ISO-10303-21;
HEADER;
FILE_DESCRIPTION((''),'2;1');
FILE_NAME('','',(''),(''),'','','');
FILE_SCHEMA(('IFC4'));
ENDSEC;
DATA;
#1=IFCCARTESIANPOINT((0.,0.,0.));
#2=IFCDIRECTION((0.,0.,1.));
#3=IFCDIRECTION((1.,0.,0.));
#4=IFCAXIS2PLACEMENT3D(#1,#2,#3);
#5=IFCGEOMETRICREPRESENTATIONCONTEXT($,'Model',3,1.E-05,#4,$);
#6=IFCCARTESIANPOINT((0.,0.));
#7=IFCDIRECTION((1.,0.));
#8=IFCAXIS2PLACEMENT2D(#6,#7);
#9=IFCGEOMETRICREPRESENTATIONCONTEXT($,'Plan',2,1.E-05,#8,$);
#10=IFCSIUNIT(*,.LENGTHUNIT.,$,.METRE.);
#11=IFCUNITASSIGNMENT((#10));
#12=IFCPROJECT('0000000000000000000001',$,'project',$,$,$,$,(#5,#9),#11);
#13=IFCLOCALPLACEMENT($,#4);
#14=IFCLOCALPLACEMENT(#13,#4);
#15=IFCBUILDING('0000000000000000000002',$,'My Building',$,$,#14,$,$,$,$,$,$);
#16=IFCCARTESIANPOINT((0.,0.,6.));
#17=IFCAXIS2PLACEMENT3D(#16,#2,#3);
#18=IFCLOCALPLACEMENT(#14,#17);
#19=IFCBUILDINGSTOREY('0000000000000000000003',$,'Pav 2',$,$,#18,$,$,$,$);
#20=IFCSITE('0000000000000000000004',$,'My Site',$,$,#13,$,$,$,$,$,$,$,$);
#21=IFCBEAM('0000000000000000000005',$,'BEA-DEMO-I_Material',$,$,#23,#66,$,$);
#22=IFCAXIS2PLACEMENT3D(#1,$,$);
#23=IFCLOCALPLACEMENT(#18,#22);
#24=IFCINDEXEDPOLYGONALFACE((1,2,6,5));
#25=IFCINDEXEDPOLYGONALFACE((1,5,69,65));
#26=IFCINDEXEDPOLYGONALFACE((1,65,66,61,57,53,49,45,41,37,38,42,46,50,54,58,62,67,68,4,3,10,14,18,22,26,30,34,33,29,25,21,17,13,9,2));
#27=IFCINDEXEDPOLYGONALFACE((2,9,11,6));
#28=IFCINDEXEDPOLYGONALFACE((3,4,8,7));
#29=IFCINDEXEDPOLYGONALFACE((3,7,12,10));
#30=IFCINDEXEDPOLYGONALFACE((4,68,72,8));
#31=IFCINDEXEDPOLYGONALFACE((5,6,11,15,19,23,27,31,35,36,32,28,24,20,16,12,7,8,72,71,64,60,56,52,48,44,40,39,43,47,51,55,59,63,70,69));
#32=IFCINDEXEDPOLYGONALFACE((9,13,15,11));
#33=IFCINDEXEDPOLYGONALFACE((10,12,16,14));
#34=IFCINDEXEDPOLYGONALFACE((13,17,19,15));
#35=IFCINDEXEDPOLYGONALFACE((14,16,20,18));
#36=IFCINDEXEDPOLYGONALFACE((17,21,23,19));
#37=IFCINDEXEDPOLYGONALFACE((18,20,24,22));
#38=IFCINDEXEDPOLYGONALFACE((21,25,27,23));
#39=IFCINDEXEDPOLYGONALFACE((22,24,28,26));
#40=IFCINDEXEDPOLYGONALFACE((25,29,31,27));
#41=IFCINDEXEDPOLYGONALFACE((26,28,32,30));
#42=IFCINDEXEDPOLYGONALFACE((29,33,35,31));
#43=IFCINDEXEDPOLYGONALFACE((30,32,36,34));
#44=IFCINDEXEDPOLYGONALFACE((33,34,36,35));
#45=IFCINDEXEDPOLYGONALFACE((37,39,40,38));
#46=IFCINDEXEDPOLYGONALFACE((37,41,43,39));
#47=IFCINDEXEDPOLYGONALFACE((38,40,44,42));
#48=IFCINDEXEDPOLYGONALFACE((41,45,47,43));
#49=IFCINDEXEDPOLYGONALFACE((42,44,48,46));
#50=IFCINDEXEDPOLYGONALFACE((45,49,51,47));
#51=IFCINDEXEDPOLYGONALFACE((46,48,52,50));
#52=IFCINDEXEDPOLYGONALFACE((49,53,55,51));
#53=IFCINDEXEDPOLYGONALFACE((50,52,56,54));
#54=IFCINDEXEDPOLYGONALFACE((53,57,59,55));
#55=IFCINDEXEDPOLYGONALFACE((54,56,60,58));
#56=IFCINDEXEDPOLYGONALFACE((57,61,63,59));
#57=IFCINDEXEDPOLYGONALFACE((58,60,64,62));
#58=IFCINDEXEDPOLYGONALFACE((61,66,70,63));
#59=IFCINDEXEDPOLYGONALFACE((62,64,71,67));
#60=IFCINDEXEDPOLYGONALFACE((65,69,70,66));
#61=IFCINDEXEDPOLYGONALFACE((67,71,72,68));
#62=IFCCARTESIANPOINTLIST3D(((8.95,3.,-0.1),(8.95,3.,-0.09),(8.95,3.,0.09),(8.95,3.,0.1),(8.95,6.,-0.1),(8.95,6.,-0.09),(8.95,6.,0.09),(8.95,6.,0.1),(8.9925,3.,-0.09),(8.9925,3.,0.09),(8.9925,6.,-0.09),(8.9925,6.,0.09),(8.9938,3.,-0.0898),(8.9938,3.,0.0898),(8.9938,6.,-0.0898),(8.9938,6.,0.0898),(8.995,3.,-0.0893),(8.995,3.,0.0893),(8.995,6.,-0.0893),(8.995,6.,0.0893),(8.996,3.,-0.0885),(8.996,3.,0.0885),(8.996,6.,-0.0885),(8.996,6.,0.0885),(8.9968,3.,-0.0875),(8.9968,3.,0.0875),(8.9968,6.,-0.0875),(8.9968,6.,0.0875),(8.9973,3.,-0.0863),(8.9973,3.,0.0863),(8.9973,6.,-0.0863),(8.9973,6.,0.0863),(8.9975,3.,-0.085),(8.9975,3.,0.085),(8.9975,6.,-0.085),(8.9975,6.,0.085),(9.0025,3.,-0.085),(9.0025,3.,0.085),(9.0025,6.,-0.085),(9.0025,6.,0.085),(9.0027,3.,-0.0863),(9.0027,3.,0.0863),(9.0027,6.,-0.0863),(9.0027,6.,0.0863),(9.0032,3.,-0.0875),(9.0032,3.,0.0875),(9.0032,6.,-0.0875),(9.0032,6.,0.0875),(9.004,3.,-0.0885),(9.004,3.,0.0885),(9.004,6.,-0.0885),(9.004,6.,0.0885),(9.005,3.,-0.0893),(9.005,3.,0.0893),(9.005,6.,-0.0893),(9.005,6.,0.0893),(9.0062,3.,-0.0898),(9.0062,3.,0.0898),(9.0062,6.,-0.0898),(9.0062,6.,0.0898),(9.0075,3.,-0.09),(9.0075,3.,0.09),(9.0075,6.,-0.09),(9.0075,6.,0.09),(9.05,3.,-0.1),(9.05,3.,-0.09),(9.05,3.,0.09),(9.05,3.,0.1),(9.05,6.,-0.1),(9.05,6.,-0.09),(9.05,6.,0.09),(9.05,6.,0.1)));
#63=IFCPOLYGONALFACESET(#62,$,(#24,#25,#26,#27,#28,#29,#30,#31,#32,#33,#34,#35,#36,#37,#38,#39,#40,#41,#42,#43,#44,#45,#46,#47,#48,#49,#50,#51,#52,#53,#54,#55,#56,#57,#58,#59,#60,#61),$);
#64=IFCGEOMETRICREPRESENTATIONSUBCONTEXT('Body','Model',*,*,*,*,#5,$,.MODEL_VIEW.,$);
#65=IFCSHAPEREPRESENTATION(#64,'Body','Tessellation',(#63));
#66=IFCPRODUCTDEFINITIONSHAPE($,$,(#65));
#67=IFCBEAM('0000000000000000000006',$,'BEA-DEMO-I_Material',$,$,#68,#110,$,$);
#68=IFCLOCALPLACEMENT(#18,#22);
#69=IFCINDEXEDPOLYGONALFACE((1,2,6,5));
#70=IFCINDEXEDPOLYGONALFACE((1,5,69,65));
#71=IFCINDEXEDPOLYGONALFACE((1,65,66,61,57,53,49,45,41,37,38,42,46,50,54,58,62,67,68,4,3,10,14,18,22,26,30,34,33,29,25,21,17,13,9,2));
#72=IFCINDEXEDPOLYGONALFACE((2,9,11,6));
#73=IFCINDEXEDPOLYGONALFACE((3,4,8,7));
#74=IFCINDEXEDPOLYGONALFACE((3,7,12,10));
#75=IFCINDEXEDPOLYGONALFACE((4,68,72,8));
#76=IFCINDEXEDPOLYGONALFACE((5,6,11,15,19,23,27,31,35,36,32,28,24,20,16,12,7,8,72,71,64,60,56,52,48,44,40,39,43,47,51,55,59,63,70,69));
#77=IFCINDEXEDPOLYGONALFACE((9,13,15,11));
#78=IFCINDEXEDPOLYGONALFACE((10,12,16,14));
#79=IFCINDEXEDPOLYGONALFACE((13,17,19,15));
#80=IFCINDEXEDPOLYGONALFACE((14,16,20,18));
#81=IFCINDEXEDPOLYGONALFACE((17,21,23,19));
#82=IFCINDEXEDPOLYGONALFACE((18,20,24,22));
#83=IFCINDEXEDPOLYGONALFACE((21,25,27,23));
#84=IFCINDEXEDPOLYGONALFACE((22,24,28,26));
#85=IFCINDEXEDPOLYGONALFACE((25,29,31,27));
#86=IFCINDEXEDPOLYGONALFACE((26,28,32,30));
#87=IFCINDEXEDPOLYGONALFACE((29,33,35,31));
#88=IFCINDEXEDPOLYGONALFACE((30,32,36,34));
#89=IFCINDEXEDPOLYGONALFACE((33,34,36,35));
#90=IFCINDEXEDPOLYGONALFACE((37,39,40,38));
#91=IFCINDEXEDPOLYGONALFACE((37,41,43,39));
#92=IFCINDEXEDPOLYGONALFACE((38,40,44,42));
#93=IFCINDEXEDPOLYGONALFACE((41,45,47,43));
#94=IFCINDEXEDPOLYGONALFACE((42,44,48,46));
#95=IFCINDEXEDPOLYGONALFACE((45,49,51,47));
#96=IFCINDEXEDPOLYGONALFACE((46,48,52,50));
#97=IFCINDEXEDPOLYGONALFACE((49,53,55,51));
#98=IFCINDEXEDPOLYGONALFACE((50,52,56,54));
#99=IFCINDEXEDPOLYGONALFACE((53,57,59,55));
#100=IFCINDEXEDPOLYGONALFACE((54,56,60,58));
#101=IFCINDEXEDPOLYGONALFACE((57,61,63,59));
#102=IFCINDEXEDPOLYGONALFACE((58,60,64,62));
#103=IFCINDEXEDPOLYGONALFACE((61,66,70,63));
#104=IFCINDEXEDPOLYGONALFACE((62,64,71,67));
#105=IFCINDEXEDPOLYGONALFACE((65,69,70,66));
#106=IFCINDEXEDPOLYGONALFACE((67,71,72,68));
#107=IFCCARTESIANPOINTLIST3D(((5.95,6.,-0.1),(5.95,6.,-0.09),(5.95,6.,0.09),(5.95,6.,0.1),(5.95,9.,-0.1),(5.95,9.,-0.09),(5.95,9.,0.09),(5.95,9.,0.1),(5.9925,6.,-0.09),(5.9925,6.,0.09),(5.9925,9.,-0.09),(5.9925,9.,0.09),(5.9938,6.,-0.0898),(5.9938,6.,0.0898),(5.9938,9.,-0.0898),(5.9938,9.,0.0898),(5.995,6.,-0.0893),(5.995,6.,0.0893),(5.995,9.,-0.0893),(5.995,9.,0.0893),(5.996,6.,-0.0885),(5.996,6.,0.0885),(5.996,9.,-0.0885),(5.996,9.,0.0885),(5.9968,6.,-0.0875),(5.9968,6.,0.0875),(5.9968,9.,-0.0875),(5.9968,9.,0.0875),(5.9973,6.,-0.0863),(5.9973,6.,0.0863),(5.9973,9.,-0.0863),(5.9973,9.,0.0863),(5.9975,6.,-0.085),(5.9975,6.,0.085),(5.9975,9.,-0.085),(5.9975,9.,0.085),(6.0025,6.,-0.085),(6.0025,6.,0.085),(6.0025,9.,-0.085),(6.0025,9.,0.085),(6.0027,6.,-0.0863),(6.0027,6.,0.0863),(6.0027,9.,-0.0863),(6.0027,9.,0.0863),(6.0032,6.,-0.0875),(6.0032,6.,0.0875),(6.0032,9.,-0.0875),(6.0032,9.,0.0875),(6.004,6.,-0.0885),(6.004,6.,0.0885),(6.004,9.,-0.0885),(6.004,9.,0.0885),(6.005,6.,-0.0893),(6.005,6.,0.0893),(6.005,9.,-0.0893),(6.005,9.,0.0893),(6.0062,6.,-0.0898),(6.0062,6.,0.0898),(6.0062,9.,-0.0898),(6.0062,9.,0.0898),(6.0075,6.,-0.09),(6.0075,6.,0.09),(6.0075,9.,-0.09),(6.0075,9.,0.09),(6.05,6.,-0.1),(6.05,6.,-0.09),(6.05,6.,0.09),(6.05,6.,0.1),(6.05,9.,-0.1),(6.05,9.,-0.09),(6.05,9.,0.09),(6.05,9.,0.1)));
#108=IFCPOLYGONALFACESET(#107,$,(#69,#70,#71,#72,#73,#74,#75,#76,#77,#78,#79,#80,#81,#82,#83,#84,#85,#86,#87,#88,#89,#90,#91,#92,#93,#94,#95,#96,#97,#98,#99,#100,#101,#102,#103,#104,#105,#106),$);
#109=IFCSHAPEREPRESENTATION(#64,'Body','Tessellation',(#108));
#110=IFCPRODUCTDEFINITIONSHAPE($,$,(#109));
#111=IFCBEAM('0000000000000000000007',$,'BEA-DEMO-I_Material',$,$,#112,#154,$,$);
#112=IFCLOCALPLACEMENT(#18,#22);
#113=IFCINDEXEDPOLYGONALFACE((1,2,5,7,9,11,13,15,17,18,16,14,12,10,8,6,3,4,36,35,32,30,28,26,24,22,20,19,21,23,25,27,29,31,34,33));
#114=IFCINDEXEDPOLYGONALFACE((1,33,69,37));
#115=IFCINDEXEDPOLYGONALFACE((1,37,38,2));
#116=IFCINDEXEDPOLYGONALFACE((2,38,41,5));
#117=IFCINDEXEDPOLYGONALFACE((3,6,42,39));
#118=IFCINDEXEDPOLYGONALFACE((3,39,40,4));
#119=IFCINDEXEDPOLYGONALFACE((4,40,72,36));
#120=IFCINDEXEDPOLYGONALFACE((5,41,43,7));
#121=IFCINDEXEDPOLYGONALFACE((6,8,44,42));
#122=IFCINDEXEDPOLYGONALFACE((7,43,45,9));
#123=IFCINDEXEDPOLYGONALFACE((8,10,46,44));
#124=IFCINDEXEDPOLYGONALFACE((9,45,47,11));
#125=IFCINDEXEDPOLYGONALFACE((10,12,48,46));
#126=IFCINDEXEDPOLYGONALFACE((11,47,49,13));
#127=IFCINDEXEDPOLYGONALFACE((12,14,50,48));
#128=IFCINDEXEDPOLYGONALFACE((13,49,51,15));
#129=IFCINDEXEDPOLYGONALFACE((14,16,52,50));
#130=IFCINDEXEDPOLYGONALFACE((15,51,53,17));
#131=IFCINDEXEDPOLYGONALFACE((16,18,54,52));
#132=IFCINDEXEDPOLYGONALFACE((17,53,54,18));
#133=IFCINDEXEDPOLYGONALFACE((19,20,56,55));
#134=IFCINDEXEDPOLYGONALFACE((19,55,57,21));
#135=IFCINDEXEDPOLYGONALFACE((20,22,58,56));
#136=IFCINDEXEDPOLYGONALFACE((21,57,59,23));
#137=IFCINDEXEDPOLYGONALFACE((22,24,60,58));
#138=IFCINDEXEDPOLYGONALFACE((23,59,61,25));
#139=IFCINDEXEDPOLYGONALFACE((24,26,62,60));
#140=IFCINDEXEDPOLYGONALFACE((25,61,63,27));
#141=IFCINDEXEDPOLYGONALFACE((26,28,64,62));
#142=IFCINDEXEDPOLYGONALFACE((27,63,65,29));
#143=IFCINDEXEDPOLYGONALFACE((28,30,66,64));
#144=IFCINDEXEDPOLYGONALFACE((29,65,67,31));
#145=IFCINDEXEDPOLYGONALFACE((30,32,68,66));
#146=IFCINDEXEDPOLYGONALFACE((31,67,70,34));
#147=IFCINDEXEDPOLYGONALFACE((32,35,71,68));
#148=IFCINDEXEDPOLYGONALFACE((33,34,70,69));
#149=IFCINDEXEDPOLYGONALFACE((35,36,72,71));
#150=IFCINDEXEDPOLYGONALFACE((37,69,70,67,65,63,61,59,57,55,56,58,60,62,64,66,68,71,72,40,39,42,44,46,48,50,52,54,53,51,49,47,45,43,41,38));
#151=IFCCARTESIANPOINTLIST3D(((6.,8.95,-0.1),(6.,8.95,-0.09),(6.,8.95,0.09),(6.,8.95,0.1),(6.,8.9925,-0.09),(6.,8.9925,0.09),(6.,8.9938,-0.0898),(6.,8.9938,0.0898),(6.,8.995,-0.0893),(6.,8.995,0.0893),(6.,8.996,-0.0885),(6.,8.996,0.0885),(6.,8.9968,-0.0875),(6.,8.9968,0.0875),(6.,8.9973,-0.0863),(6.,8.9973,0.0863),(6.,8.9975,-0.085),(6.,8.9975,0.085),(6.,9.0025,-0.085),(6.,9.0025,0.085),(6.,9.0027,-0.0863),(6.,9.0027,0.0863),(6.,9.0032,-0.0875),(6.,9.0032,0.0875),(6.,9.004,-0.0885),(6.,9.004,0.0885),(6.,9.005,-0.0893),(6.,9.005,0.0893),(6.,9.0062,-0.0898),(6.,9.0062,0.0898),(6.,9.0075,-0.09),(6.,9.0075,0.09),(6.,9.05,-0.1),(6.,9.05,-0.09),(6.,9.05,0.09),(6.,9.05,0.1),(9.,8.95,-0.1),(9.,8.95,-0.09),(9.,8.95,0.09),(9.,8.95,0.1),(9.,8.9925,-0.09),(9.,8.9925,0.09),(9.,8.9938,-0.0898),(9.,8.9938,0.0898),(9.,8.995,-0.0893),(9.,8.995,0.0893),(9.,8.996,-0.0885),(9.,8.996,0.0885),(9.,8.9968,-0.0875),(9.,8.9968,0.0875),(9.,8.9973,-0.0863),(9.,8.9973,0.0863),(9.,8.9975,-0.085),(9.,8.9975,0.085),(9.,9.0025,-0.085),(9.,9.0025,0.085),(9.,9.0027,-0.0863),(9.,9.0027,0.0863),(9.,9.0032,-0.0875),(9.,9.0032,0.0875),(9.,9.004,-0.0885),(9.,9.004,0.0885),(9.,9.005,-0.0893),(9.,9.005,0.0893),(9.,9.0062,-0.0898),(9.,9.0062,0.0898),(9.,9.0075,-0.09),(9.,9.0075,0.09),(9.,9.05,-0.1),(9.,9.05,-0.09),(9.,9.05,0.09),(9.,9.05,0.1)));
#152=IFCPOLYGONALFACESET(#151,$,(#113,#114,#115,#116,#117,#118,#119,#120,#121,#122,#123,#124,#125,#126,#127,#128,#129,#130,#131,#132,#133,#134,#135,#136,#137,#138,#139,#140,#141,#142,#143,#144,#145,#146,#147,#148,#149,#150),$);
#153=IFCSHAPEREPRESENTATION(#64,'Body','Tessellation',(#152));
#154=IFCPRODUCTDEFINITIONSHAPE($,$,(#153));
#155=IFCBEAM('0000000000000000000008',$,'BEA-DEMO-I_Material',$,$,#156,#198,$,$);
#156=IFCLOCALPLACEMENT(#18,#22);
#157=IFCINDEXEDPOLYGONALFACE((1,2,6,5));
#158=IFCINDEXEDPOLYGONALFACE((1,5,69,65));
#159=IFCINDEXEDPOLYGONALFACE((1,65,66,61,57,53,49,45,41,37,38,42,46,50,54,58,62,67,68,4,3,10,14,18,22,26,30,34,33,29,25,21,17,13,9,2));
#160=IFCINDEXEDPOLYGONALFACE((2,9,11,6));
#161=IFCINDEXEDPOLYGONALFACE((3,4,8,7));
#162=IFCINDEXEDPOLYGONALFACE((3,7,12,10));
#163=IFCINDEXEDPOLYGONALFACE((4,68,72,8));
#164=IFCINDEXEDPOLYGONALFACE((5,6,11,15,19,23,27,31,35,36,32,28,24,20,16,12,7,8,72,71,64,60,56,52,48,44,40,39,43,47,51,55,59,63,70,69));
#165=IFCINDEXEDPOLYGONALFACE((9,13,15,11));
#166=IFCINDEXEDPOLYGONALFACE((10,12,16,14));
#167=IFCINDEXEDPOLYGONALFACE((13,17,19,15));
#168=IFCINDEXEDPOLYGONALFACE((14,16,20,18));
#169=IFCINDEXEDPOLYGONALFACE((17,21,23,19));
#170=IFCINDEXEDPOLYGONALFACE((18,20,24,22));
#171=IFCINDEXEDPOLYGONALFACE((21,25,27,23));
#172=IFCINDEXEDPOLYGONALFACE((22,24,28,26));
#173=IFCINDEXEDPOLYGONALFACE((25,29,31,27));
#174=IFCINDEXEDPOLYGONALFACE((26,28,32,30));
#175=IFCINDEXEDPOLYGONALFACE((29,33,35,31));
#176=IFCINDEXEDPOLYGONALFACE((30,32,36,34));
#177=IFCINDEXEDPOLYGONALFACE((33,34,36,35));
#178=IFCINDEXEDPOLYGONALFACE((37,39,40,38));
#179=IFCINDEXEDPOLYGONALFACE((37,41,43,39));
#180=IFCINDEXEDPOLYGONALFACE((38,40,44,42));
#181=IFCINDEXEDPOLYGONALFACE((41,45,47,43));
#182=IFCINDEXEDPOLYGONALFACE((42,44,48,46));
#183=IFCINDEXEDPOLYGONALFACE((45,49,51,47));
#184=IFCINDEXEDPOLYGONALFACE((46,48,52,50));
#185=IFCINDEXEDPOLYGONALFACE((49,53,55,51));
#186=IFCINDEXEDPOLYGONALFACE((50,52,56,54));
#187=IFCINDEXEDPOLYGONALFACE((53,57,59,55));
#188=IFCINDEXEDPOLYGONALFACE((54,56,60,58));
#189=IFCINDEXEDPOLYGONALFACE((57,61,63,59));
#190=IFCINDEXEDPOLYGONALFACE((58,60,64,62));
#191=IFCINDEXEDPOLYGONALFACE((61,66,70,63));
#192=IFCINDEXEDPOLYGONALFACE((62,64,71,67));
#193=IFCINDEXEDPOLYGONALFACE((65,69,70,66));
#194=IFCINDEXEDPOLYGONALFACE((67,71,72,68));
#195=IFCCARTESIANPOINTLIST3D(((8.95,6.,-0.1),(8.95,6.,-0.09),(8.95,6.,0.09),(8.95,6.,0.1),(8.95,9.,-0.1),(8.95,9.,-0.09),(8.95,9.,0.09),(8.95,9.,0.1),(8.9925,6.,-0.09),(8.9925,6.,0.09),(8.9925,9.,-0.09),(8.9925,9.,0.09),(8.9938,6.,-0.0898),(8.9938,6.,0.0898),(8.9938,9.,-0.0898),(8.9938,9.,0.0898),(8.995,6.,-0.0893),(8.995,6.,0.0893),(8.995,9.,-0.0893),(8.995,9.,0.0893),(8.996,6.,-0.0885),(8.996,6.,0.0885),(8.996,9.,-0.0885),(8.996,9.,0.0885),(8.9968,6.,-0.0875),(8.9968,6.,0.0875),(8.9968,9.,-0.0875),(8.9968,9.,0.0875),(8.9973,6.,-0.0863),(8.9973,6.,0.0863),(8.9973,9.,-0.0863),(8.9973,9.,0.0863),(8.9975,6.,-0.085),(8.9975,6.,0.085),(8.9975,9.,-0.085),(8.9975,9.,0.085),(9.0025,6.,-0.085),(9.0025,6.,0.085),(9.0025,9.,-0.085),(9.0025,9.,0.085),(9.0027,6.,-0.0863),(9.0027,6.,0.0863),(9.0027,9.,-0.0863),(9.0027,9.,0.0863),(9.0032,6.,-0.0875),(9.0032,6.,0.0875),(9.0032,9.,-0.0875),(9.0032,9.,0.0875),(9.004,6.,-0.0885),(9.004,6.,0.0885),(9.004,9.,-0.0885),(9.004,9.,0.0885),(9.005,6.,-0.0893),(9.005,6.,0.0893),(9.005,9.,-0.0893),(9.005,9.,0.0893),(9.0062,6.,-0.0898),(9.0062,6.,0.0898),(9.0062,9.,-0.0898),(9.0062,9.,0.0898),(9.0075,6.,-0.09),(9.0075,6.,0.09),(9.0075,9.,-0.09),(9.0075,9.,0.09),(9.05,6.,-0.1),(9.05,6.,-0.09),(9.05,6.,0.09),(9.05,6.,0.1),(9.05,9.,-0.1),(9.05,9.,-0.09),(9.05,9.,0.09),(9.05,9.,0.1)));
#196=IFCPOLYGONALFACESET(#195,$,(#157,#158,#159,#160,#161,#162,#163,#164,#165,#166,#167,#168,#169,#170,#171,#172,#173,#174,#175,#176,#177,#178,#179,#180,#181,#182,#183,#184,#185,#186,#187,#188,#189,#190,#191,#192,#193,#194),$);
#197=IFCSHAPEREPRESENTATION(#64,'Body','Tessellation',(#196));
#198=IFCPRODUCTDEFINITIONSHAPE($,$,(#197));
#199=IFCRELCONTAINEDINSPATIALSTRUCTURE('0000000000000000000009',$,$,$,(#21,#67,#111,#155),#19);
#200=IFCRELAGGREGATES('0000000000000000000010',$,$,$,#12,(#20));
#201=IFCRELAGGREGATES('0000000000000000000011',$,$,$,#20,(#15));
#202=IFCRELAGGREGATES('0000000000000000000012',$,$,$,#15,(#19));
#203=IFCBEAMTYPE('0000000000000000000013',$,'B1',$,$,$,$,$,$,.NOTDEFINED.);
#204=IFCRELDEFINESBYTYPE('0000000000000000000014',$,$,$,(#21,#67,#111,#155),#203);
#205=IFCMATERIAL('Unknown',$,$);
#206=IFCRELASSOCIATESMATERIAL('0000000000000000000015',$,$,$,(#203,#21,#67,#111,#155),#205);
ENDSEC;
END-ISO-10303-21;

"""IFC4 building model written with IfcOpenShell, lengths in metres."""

from ifc_helpers import new_model, si_unit, frame, origin, origin_with_axes, origin_2d_with_axis, place, context, subcontext, project, spatial, i_section, extrude, material, material_profile, profile_set, profile_usage, type_object, element, save


model = new_model("IFC4")

# Units and contexts
model_context = context("Model", 3, precision=1e-05, world=origin_with_axes())
plan_context = context("Plan", 2, precision=1e-05, world=origin_2d_with_axis())
body_context = subcontext(model_context, "Body", "Model", "MODEL_VIEW")
ifc_project = project(units=[si_unit("LENGTHUNIT", "METRE")], contexts=[model_context, plan_context])

# Site, building, storey
site_placement = place(None, origin_with_axes())
site = spatial("IfcSite", under=ifc_project, at=site_placement, Name="My Site")
building_placement = place(site_placement, origin_with_axes())
building = spatial("IfcBuilding", under=site, at=building_placement, Name="My Building")
storey_placement = place(building_placement, frame((0.0, 0.0, 6.0), z_axis=(0.0, 0.0, 1.0), x_axis=(1.0, 0.0, 0.0)))
storey = spatial("IfcBuildingStorey", under=building, at=storey_placement, Name="Pav 2")

# Beams
ifc_material = material(Name="Unknown")
ifc_material_profile = material_profile(ifc_material, i_section(OverallWidth=0.1, OverallDepth=0.2, WebThickness=0.005, FlangeThickness=0.01, FilletRadius=0.005))
ifc_profile_set = profile_set([ifc_material_profile])
beam_type = type_object("IfcBeamType", Name="B1", PredefinedType="NOTDEFINED", material=ifc_profile_set)
ifc_profile_usage_1 = profile_usage(ifc_profile_set, cardinal=5)
beam_1_placement = place(storey_placement, frame((9.0, 6.0, 0.0), z_axis=(0.0, -1.0, 0.0), x_axis=(1.0, 0.0, 0.0)))
element("IfcBeam", 1, at=beam_1_placement, inside=storey, type_object=beam_type, material=ifc_profile_usage_1, Name="BEA-DEMO-I_Material", context=body_context, shape_type="SweptSolid", body=[
    extrude(i_section(OverallWidth=0.1, OverallDepth=0.2, WebThickness=0.005, FlangeThickness=0.01, FilletRadius=0.005), origin(), (0.0, 0.0, 1.0), 3.0),
])
ifc_profile_usage_2 = profile_usage(ifc_profile_set, cardinal=5)
beam_2_placement = place(storey_placement, frame((6.0, 9.0, 0.0), z_axis=(0.0, -1.0, 0.0), x_axis=(1.0, 0.0, 0.0)))
element("IfcBeam", 2, at=beam_2_placement, inside=storey, type_object=beam_type, material=ifc_profile_usage_2, Name="BEA-DEMO-I_Material", context=body_context, shape_type="SweptSolid", body=[
    extrude(i_section(OverallWidth=0.1, OverallDepth=0.2, WebThickness=0.005, FlangeThickness=0.01, FilletRadius=0.005), origin(), (0.0, 0.0, 1.0), 3.0),
])
ifc_profile_usage_3 = profile_usage(ifc_profile_set, cardinal=5)
beam_3_placement = place(storey_placement, frame((6.0, 9.0, 0.0), z_axis=(1.0, 0.0, 0.0), x_axis=(0.0, 1.0, 0.0)))
element("IfcBeam", 3, at=beam_3_placement, inside=storey, type_object=beam_type, material=ifc_profile_usage_3, Name="BEA-DEMO-I_Material", context=body_context, shape_type="SweptSolid", body=[
    extrude(i_section(OverallWidth=0.1, OverallDepth=0.2, WebThickness=0.005, FlangeThickness=0.01, FilletRadius=0.005), origin(), (0.0, 0.0, 1.0), 3.0),
])
ifc_profile_usage_4 = profile_usage(ifc_profile_set, cardinal=5)
beam_4_placement = place(storey_placement, frame((9.0, 9.0, 0.0), z_axis=(0.0, -1.0, 0.0), x_axis=(1.0, 0.0, 0.0)))
element("IfcBeam", 4, at=beam_4_placement, inside=storey, type_object=beam_type, material=ifc_profile_usage_4, Name="BEA-DEMO-I_Material", context=body_context, shape_type="SweptSolid", body=[
    extrude(i_section(OverallWidth=0.1, OverallDepth=0.2, WebThickness=0.005, FlangeThickness=0.01, FilletRadius=0.005), origin(), (0.0, 0.0, 1.0), 3.0),
])

save(model, "model.ifc")
